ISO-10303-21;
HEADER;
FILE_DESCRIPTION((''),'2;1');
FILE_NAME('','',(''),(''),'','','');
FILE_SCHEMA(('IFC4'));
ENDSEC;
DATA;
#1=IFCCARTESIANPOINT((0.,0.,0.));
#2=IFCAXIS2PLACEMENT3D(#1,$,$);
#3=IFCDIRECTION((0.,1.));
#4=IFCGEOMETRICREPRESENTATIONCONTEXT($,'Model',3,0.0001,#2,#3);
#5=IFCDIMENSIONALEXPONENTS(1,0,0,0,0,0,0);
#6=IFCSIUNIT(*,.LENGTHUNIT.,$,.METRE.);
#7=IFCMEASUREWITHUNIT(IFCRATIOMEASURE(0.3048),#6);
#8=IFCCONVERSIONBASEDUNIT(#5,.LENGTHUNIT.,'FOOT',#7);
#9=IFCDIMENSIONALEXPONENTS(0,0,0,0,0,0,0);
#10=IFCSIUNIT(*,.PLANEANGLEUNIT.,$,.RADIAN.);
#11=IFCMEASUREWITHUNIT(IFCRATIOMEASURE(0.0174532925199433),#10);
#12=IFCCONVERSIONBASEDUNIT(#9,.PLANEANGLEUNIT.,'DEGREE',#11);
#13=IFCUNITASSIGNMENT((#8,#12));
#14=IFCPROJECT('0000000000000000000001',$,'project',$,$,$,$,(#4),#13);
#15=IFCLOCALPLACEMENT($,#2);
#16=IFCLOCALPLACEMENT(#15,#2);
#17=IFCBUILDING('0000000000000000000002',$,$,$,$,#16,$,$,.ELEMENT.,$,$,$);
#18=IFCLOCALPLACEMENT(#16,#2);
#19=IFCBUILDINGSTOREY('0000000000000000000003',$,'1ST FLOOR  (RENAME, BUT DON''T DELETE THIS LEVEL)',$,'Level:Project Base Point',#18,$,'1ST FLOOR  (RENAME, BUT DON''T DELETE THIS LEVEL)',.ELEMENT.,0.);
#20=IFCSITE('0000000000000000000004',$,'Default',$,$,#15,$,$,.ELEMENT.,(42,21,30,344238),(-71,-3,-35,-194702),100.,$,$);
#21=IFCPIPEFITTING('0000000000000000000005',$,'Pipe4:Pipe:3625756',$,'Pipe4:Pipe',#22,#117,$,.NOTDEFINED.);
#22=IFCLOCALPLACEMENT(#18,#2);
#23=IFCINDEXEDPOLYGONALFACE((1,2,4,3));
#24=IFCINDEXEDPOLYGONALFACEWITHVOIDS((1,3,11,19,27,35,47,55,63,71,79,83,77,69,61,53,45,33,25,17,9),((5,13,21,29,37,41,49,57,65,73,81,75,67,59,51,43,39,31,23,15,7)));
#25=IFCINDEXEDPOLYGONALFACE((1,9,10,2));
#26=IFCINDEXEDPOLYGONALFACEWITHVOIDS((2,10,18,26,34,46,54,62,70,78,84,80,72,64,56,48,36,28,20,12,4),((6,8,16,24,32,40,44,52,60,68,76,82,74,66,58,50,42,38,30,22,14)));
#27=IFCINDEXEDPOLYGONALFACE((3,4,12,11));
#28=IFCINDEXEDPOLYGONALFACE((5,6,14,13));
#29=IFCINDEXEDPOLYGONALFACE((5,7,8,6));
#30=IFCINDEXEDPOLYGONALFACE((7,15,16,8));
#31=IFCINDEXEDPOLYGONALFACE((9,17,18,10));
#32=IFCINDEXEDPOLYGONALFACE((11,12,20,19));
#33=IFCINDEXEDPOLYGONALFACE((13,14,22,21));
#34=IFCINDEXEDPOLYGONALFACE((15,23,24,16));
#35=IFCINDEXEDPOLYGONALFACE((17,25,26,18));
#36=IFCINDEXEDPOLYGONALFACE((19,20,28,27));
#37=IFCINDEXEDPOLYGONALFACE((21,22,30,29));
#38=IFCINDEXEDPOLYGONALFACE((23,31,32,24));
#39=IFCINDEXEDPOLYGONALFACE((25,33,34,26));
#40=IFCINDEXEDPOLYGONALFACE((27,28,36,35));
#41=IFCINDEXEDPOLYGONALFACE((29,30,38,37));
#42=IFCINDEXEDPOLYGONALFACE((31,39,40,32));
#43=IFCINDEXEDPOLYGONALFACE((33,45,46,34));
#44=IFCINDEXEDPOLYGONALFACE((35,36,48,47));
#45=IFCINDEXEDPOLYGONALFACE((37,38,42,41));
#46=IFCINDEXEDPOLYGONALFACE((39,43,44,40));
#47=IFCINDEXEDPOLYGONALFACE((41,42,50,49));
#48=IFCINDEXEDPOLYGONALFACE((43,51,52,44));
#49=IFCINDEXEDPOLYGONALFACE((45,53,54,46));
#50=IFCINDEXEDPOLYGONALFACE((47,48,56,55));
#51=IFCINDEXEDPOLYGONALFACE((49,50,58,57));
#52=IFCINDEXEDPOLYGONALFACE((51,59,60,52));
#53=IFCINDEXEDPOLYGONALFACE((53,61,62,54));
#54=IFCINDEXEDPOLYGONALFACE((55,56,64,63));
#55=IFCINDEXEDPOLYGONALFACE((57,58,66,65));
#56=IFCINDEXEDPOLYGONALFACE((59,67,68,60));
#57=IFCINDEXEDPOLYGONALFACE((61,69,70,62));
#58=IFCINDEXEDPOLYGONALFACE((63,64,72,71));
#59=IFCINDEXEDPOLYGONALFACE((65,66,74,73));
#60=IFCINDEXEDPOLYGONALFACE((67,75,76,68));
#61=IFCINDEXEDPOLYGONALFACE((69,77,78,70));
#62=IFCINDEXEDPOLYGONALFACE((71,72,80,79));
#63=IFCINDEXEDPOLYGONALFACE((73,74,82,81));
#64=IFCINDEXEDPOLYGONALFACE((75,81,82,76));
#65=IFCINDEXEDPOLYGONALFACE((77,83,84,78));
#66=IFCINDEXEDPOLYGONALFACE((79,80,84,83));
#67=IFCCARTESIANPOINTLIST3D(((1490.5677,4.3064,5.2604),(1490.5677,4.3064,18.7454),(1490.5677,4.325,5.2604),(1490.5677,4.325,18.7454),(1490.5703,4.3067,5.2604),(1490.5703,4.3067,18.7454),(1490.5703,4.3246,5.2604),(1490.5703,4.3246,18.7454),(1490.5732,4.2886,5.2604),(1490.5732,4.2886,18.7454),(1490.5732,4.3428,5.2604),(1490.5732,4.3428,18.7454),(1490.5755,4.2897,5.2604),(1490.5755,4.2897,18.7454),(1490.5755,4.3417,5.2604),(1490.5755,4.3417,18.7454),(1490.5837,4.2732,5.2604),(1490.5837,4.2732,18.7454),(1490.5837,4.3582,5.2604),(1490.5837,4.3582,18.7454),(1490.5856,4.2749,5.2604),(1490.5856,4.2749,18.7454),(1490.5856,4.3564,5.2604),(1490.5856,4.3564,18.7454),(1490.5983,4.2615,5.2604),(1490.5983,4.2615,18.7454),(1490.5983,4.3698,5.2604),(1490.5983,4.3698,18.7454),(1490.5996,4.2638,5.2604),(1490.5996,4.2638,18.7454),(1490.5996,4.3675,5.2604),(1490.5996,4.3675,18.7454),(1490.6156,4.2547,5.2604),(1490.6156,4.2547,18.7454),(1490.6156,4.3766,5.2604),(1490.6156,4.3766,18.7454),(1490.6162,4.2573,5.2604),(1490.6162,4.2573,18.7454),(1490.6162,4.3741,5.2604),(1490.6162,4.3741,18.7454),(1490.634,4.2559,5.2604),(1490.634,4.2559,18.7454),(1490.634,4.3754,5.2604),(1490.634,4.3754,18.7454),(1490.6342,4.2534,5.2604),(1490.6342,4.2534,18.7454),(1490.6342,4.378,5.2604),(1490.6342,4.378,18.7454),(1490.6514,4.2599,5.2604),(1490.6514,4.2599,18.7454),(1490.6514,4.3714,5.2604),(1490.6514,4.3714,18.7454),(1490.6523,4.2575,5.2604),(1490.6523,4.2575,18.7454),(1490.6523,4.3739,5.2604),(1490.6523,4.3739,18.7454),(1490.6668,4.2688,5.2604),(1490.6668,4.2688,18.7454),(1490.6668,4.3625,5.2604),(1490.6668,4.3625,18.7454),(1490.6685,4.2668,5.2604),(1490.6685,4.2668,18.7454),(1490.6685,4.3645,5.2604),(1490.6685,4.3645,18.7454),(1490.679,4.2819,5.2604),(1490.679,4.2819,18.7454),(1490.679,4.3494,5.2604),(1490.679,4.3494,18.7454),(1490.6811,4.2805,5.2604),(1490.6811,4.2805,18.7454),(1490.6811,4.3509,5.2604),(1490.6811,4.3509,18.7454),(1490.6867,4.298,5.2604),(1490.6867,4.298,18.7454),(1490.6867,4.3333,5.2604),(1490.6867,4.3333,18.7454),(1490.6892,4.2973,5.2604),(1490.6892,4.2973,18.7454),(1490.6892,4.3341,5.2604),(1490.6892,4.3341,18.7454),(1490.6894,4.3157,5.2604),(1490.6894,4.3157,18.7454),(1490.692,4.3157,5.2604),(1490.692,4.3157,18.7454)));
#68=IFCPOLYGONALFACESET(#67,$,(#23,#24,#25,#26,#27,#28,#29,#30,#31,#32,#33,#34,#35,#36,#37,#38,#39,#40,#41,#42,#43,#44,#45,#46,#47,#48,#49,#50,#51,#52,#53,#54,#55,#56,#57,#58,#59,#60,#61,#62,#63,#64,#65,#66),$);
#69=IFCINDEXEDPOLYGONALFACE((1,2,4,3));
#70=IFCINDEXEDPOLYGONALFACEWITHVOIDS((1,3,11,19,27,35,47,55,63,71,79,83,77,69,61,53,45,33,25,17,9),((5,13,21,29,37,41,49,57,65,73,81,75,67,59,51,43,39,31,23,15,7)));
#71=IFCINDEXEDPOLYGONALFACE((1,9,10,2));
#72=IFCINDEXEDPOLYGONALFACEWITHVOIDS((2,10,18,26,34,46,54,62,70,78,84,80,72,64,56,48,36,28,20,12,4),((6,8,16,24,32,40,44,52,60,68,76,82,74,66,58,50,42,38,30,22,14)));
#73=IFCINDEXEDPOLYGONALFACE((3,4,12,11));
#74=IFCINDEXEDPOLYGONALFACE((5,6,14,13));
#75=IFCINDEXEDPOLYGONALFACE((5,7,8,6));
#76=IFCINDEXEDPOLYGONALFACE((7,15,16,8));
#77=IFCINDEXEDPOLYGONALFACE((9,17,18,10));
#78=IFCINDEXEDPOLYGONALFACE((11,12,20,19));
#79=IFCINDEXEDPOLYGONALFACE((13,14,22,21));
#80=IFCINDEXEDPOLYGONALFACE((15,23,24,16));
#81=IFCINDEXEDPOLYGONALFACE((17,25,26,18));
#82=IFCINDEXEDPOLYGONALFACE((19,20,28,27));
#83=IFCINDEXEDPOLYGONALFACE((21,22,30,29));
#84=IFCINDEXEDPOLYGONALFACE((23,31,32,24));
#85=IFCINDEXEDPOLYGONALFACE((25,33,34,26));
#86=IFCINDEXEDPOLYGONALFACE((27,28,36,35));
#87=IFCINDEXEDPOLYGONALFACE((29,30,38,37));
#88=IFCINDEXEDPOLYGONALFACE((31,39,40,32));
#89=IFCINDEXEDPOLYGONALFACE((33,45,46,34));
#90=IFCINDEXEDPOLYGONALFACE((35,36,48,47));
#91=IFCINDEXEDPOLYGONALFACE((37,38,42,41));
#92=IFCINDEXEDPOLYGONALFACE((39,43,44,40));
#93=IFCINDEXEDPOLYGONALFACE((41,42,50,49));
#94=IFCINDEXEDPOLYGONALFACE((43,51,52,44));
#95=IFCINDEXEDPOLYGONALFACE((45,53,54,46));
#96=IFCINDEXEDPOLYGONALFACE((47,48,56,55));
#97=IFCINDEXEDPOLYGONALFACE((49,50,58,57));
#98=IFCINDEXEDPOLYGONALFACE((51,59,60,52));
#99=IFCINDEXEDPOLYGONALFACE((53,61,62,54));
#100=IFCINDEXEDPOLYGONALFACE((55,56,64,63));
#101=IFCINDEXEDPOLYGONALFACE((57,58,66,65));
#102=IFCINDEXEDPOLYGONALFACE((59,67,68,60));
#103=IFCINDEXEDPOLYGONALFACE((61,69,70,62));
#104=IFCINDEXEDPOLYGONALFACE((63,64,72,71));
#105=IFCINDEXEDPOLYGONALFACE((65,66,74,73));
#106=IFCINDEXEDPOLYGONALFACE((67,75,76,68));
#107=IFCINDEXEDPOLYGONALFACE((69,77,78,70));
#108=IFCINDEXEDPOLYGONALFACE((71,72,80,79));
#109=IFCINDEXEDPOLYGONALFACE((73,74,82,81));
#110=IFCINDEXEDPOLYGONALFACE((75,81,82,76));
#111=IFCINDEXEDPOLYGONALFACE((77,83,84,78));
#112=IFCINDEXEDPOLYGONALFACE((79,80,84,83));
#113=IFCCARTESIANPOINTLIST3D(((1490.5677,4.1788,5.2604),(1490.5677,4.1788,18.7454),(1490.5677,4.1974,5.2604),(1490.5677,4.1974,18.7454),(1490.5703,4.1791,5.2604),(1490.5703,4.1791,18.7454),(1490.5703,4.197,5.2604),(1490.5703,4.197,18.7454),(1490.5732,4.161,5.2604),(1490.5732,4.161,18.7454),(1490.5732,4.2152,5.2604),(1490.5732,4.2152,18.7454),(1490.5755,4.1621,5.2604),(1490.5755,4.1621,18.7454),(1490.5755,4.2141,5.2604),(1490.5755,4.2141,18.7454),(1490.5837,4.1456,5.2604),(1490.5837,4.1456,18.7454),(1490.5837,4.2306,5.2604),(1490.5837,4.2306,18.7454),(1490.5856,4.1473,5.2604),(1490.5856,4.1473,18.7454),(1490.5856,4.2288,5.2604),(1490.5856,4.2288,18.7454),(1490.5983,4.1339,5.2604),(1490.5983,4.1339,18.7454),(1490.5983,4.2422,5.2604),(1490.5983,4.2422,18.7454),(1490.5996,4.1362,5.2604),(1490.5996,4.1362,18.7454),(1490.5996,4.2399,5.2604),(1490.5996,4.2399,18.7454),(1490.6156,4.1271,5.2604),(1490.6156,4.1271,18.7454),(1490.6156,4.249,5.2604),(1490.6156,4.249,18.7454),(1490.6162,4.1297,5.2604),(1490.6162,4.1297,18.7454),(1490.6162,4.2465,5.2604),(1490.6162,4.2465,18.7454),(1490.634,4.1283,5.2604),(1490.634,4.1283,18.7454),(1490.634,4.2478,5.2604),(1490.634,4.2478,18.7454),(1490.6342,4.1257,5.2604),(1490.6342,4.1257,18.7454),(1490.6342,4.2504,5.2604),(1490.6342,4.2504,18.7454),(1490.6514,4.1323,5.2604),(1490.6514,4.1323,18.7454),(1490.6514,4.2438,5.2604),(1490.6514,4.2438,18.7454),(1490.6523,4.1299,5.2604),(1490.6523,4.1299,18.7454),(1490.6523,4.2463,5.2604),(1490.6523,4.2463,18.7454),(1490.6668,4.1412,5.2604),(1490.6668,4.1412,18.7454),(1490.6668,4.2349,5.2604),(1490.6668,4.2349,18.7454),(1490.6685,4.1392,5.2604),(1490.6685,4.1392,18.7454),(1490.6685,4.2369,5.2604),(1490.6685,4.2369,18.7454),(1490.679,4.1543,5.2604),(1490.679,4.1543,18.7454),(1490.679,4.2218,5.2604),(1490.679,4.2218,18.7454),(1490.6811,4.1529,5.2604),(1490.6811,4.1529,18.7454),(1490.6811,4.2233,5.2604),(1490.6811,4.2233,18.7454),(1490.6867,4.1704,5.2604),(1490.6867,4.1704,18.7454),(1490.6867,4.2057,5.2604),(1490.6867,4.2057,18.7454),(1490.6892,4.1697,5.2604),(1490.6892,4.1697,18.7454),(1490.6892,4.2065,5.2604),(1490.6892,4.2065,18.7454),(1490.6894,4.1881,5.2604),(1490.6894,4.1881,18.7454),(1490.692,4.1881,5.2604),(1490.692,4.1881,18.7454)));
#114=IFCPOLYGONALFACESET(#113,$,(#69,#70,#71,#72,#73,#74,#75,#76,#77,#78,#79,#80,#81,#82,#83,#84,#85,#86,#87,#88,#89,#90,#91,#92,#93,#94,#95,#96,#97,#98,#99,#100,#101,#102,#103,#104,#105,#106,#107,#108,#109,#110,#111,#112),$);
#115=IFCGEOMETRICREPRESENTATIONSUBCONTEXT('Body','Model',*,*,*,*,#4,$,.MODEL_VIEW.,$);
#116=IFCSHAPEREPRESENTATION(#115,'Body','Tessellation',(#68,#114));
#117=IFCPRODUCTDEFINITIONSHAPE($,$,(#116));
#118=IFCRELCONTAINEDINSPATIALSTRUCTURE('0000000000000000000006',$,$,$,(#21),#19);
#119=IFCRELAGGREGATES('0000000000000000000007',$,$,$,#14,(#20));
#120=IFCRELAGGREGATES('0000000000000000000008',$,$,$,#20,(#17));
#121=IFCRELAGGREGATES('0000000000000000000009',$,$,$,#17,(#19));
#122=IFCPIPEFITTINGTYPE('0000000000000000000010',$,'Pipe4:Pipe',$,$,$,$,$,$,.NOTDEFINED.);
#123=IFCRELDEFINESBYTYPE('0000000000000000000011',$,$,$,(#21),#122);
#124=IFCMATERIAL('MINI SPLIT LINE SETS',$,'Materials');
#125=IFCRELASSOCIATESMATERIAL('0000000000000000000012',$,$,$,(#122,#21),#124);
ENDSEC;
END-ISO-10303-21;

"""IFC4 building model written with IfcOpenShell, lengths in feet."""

from ifc_helpers import new_model, entity, si_unit, converted_unit, direction, frame, origin, origin_2d_with_axis, place, context, subcontext, project, spatial, hollow_circle, extrude, source, transform, mapped, material, type_object, type_shapes, element, save


model = new_model("IFC4")

# Units and contexts
model_context = context("Model", 3, precision=0.0001, world=origin(), true_north=direction((0.0, 1.0)))
body_context = subcontext(model_context, "Body", "Model", "MODEL_VIEW")
ifc_project = project(units=[converted_unit("LENGTHUNIT", "FOOT", entity("IfcRatioMeasure", 0.3048), si_unit("LENGTHUNIT", "METRE"), dimensions=[1, 0, 0, 0, 0, 0, 0]), converted_unit("PLANEANGLEUNIT", "DEGREE", entity("IfcRatioMeasure", 0.0174532925199433), si_unit("PLANEANGLEUNIT", "RADIAN"), dimensions=[0, 0, 0, 0, 0, 0, 0])], contexts=[model_context])

# Site, building, storey
site_placement = place(None, origin())
site = spatial("IfcSite", under=ifc_project, at=site_placement, Name="Default", CompositionType="ELEMENT", RefLatitude=(42, 21, 30, 344238), RefLongitude=(-71, -3, -35, -194702), RefElevation=100.0)
building_placement = place(site_placement, origin())
building = spatial("IfcBuilding", under=site, at=building_placement, CompositionType="ELEMENT")
storey_placement = place(building_placement, origin())
storey = spatial("IfcBuildingStorey", under=building, at=storey_placement, Name="1ST FLOOR  (RENAME, BUT DON'T DELETE THIS LEVEL)", ObjectType="Level:Project Base Point", LongName="1ST FLOOR  (RENAME, BUT DON'T DELETE THIS LEVEL)", CompositionType="ELEMENT", Elevation=0.0)

# Shared definitions
ifc_material_1 = material(Name="MINI SPLIT LINE SETS", Category="Materials")

# Pipe fitting
pipe_fitting_type_1 = type_object("IfcPipeFittingType", Name="Pipe4:Pipe", PredefinedType="NOTDEFINED", material=ifc_material_1)
shared_shape_1 = source(origin(), body_context, "Body", "SweptSolid", [
    extrude(hollow_circle(Radius=0.0625, WallThickness=0.0026, at=origin_2d_with_axis()), frame((0.0677, 0.1953, 0.0)), (0.0, 0.0, 1.0), 13.485),
    extrude(hollow_circle(Radius=0.0625, WallThickness=0.0026, at=origin_2d_with_axis()), frame((0.0677, 0.0677, 0.0)), (0.0, 0.0, 1.0), 13.485),
])
type_shapes(pipe_fitting_type_1, [shared_shape_1])
pipe_fitting_1_placement = place(storey_placement, frame((1490.5618, 4.1203, 5.2604)))
element("IfcPipeFitting", 1, at=pipe_fitting_1_placement, inside=storey, type_object=pipe_fitting_type_1, material=ifc_material_1, Name="Pipe4:Pipe:3625756", ObjectType="Pipe4:Pipe", PredefinedType="NOTDEFINED", context=body_context, shape_type="MappedRepresentation", body=[
    mapped(shared_shape_1, transform((0.0, 0.0, 0.0), scale=1.0)),
])

save(model, "model.ifc")
